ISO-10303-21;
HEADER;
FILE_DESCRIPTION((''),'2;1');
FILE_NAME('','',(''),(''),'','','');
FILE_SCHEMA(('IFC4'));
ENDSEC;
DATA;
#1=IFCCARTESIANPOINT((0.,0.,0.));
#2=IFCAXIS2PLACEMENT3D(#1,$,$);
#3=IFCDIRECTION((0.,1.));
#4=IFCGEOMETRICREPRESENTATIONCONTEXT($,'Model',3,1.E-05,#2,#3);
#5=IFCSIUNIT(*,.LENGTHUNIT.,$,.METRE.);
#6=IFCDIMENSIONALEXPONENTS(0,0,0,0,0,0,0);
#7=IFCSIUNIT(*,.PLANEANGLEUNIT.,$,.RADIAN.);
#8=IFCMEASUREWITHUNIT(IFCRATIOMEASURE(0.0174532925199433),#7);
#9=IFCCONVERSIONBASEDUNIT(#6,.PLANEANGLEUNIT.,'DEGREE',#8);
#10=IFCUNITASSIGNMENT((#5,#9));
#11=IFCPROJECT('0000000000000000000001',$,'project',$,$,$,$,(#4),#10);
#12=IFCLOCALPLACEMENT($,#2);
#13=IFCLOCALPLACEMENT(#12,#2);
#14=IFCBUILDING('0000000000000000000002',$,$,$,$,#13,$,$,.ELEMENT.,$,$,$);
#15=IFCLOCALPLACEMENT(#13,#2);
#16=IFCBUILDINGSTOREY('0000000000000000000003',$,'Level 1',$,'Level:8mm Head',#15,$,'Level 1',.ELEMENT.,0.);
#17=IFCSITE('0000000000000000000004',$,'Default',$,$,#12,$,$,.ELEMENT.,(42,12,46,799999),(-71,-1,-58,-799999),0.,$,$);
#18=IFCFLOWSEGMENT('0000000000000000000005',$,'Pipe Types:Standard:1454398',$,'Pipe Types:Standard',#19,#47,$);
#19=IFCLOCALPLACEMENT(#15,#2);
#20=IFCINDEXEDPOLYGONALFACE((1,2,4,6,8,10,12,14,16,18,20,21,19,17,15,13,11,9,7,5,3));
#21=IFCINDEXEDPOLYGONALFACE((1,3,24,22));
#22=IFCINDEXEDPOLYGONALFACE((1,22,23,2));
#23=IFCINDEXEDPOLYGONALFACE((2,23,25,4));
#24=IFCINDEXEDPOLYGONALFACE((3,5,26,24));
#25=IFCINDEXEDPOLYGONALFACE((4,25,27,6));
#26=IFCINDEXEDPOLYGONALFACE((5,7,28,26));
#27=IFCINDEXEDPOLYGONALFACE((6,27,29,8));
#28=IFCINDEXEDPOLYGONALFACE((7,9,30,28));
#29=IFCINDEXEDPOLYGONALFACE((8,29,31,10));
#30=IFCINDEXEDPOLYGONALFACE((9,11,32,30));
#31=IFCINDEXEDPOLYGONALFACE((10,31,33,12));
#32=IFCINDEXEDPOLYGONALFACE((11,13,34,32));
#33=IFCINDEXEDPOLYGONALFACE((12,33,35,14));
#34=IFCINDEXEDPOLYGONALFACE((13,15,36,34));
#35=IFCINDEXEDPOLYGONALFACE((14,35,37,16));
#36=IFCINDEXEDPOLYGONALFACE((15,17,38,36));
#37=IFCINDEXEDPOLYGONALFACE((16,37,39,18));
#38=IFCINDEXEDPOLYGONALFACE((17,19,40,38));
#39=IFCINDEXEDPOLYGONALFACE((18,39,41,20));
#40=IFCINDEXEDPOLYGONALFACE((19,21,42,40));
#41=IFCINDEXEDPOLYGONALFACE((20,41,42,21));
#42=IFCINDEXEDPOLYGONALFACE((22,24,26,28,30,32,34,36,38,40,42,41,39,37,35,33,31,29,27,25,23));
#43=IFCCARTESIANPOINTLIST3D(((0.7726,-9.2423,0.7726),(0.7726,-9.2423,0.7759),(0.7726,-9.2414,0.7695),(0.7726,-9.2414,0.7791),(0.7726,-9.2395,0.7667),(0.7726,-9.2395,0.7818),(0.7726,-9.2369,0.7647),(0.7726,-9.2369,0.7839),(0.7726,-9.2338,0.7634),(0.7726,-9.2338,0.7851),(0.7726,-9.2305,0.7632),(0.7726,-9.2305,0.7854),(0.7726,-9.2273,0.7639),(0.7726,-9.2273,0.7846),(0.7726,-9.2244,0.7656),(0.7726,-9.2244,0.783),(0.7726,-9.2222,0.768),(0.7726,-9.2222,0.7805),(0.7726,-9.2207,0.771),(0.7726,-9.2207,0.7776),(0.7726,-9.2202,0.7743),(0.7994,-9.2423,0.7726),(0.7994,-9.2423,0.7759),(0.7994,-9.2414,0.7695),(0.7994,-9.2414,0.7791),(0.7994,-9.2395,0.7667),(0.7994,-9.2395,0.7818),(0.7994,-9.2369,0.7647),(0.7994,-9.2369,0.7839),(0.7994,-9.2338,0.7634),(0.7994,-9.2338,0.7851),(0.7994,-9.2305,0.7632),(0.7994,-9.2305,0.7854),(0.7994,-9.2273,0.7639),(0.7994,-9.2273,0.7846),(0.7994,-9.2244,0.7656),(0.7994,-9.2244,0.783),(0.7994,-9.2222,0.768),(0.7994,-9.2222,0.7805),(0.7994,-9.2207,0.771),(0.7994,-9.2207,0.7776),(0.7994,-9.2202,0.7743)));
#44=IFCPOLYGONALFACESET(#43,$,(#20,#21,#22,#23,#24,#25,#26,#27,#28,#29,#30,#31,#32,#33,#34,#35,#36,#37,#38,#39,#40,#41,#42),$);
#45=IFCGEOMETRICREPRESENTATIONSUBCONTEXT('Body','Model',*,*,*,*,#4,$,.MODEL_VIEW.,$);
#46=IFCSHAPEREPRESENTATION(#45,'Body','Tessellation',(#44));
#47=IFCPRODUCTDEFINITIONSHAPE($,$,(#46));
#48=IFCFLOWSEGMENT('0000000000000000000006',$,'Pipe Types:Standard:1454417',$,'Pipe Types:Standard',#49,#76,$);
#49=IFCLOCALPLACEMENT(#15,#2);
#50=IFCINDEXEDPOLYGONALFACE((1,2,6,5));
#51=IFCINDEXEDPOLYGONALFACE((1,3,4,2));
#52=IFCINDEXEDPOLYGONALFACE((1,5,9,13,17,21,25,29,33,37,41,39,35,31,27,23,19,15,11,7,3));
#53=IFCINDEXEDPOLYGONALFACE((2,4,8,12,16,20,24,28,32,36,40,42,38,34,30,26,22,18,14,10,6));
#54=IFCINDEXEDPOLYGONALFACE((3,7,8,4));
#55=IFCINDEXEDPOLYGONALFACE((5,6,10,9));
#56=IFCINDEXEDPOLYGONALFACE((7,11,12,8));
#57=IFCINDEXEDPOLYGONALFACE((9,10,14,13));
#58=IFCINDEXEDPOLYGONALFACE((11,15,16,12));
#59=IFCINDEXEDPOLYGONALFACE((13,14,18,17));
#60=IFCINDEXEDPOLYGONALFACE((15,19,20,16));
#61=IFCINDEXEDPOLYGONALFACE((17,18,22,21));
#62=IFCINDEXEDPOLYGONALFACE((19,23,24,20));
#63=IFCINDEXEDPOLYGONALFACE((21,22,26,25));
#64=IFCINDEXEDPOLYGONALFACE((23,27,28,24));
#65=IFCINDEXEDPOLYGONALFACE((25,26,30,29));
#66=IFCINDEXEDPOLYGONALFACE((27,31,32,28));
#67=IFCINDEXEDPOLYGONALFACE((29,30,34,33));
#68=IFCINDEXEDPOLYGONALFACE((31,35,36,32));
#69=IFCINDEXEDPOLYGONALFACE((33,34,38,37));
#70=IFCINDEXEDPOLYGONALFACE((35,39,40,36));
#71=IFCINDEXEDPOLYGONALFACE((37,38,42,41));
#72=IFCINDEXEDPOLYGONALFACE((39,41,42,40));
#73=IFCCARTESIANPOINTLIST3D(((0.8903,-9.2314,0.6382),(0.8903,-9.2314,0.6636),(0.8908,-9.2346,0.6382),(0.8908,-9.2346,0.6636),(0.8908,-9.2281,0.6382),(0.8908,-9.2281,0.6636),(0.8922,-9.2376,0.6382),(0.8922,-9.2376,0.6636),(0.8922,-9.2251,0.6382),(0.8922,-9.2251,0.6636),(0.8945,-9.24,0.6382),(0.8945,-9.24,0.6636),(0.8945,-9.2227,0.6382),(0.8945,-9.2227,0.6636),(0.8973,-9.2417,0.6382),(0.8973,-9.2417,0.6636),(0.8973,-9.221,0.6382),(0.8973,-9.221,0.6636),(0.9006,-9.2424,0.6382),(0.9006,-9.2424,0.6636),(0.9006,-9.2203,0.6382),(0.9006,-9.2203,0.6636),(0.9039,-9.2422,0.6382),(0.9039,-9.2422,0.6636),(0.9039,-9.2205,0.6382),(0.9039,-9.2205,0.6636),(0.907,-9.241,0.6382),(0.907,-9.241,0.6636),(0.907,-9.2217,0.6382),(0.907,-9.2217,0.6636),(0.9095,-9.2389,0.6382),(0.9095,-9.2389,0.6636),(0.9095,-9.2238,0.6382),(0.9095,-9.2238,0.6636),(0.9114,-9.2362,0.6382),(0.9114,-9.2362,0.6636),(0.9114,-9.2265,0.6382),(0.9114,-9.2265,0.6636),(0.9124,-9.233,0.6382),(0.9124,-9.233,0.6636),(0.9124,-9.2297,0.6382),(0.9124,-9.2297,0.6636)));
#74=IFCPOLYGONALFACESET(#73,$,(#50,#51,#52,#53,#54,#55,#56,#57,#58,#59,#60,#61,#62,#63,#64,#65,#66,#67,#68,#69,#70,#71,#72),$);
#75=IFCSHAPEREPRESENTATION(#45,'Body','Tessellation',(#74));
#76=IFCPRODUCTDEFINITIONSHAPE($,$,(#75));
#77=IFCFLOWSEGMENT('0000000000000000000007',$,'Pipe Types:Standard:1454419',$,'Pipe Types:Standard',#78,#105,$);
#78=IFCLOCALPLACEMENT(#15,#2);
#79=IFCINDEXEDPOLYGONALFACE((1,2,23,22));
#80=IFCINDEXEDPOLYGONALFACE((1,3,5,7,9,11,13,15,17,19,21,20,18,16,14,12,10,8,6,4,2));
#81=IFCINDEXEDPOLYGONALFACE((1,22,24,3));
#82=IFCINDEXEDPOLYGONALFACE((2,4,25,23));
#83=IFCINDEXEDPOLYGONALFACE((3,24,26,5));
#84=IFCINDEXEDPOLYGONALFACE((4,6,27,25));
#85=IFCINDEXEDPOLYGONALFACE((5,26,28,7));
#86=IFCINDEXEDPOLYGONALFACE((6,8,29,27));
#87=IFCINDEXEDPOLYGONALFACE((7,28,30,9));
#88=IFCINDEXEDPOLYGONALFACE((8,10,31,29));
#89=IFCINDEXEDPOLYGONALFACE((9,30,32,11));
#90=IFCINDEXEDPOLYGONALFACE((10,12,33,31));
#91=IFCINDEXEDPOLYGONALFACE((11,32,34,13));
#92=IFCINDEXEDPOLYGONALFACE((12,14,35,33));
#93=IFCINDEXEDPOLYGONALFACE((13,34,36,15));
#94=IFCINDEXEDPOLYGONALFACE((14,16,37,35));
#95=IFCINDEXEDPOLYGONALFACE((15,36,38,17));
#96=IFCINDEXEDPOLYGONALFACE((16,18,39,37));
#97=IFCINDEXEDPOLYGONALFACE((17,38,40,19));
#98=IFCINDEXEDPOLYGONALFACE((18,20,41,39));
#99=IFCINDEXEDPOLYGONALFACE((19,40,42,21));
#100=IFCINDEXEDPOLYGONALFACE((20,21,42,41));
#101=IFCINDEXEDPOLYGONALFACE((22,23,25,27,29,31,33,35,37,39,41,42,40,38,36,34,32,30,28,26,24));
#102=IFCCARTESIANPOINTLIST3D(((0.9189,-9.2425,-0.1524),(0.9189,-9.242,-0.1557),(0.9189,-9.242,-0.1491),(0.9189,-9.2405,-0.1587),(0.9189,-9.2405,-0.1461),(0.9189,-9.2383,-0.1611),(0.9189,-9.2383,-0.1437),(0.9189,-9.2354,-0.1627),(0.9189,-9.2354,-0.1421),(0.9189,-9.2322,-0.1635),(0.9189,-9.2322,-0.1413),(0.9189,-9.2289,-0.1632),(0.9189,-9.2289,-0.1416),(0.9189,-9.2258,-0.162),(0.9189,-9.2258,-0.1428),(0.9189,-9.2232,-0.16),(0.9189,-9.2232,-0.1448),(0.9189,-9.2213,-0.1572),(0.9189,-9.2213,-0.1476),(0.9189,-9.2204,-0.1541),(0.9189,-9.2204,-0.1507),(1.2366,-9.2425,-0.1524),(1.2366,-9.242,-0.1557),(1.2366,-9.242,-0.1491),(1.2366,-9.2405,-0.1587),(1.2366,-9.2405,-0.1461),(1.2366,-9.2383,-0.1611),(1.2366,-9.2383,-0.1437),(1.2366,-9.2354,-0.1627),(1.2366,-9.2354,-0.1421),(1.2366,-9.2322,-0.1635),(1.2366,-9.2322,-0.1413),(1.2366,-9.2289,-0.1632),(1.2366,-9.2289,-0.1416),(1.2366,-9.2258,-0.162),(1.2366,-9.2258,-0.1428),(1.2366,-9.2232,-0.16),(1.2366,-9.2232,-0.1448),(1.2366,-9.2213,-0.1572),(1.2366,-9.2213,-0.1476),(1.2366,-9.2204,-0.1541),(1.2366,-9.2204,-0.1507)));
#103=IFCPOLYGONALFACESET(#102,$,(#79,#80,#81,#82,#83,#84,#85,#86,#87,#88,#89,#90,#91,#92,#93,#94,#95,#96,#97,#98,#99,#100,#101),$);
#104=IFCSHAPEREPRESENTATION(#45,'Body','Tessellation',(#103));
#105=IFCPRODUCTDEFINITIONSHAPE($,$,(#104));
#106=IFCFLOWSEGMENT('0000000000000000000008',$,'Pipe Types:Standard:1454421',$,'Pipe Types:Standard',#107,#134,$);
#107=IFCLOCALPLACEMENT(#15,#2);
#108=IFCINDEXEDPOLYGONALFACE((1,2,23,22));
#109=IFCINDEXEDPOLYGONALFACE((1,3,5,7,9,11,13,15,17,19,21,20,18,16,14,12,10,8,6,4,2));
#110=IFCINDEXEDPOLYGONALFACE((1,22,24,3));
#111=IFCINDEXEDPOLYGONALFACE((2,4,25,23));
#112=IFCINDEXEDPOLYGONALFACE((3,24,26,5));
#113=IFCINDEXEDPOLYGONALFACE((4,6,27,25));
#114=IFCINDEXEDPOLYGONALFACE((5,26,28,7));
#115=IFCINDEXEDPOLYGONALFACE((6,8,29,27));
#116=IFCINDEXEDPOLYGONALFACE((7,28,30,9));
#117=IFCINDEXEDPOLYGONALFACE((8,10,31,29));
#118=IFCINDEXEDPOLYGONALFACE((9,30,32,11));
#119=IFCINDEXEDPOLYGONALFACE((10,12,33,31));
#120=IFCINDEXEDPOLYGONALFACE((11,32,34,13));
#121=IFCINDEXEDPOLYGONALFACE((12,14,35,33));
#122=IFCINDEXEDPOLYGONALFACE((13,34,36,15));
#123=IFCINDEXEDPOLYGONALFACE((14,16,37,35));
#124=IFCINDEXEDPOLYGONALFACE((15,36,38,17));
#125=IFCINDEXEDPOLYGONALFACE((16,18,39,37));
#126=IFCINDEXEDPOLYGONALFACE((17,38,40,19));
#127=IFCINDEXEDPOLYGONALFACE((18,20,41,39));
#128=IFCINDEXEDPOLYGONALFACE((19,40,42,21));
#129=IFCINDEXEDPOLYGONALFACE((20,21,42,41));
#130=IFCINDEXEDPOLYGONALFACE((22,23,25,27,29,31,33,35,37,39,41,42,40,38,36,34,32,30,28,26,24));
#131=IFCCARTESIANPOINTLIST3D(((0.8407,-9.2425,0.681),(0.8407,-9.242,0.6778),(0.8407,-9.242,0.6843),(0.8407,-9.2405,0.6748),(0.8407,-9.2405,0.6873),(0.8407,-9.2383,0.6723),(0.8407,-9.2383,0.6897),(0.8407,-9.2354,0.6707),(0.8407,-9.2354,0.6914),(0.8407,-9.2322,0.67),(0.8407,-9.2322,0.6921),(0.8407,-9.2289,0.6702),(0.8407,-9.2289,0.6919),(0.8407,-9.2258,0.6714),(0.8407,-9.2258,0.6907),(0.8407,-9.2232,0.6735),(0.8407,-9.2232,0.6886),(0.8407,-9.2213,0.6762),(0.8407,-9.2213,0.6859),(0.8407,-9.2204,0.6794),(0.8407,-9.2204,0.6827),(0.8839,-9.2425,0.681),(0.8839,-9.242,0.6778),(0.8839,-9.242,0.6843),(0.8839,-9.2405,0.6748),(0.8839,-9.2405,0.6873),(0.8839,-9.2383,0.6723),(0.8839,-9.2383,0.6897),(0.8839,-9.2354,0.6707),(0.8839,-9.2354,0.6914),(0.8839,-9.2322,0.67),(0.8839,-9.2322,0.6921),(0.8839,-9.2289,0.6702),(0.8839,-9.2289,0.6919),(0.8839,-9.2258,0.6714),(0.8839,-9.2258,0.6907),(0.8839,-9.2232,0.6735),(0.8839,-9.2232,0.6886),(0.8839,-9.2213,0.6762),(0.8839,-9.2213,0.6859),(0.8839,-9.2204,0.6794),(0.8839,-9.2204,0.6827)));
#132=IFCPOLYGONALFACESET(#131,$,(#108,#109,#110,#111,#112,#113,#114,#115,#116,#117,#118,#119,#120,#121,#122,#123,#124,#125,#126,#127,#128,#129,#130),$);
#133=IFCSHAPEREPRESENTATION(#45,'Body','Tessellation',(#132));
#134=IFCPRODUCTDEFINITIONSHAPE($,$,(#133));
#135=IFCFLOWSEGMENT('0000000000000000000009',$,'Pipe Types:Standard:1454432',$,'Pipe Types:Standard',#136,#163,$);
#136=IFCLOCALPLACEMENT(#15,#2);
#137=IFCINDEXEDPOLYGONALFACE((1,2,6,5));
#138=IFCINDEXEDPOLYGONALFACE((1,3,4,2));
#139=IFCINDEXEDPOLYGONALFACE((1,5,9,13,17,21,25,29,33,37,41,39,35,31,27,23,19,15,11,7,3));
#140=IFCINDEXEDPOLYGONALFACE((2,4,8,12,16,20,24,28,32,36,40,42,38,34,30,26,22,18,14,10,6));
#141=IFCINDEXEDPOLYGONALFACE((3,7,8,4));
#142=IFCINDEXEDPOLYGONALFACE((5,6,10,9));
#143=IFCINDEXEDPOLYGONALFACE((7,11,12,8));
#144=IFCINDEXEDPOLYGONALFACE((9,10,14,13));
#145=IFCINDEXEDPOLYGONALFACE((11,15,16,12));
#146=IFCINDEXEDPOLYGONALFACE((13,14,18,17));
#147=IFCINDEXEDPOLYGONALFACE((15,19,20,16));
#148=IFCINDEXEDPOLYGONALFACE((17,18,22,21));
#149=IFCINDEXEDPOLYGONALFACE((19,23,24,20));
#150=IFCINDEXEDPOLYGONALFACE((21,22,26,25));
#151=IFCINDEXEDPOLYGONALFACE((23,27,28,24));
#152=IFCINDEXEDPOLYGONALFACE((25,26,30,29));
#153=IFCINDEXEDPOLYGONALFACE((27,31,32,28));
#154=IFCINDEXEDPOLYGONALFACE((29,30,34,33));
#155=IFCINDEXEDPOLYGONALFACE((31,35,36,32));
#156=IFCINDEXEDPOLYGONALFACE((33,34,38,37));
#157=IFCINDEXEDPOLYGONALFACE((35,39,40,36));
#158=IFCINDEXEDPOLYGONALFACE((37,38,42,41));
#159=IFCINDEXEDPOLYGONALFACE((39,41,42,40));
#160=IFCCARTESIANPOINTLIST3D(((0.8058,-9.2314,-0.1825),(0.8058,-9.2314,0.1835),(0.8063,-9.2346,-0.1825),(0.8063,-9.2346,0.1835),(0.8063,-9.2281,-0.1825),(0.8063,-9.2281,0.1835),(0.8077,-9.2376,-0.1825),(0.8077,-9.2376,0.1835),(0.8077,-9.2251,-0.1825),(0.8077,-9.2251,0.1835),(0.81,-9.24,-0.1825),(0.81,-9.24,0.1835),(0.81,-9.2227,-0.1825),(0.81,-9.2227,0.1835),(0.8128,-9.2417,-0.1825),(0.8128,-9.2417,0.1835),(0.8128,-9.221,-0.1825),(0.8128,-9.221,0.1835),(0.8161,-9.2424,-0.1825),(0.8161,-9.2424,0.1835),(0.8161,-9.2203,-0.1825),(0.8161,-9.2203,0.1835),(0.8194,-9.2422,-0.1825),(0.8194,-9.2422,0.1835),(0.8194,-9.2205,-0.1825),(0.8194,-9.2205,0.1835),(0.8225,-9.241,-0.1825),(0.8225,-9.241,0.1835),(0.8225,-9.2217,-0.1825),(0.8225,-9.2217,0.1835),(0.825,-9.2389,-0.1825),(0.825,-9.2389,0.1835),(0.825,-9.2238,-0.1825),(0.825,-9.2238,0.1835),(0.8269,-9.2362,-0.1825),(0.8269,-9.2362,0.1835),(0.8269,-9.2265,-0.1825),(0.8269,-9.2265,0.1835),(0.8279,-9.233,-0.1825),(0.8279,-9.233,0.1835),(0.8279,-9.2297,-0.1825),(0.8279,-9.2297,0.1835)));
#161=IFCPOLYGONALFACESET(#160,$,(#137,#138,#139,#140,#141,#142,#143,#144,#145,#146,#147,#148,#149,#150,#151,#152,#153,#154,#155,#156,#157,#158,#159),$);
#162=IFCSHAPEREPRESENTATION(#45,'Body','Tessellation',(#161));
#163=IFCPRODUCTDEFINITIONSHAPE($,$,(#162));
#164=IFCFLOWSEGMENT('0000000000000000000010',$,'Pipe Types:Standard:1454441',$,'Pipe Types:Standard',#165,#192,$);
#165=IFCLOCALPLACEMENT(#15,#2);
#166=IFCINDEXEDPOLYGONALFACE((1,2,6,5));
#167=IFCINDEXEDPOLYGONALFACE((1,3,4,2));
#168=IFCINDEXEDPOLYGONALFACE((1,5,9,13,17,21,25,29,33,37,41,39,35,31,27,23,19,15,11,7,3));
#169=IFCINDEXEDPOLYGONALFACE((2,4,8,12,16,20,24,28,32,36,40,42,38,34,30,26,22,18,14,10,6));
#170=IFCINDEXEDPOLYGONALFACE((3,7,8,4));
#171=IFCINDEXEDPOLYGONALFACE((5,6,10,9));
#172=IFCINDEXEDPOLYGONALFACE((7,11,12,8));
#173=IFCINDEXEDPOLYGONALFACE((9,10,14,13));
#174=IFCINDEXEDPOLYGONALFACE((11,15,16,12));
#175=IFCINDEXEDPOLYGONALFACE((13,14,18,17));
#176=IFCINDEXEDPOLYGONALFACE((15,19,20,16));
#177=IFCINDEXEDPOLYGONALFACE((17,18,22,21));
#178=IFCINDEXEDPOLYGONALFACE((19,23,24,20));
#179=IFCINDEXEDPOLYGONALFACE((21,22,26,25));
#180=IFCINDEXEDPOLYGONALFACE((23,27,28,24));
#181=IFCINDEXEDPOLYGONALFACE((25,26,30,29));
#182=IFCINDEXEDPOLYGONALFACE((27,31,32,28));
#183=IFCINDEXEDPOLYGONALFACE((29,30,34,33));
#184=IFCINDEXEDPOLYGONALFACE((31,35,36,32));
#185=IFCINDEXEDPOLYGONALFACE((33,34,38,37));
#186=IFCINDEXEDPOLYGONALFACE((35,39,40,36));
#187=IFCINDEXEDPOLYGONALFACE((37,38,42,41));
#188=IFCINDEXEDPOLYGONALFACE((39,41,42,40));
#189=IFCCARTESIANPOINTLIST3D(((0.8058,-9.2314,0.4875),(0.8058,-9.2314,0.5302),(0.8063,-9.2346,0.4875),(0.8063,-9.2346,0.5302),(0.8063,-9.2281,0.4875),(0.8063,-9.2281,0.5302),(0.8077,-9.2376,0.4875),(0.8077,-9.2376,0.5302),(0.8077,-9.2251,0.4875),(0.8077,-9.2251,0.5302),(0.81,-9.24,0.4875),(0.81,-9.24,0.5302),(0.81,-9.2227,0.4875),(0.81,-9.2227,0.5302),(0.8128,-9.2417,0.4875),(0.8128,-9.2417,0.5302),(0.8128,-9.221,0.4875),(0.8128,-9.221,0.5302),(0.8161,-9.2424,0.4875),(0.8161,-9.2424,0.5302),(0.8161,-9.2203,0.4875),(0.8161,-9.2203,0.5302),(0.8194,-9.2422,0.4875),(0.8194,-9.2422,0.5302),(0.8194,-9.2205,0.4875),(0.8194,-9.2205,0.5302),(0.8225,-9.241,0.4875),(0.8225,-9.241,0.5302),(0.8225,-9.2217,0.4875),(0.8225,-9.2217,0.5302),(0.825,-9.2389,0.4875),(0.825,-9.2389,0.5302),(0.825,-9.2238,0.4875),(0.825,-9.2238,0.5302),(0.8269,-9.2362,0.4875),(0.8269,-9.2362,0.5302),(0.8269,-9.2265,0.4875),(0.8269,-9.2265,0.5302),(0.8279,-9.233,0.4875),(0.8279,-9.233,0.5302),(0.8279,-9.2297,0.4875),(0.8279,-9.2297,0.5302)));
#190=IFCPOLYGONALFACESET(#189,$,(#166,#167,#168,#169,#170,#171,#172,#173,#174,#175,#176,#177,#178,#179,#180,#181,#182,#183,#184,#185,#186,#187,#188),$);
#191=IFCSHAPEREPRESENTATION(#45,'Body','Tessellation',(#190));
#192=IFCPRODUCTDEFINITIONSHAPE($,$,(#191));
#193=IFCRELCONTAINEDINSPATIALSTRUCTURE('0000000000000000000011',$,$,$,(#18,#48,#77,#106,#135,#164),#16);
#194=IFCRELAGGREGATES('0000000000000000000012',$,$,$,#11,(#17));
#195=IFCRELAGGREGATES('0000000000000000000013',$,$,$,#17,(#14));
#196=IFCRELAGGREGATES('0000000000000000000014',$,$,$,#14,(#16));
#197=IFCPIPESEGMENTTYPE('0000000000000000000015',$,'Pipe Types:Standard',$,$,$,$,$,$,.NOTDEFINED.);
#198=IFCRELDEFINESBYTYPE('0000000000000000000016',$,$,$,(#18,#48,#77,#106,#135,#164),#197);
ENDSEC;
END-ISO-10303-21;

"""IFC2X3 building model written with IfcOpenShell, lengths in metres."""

from ifc_helpers import new_model, entity, si_unit, converted_unit, direction, frame, frame_2d, origin, origin_2d_with_axis, place, context, subcontext, project, spatial, circle, extrude, type_object, element, save


model = new_model("IFC2X3")

# Units and contexts
model_context = context("Model", 3, precision=1e-05, world=origin(), true_north=direction((0.0, 1.0)))
body_context = subcontext(model_context, "Body", "Model", "MODEL_VIEW")
ifc_project = project(units=[si_unit("LENGTHUNIT", "METRE"), converted_unit("PLANEANGLEUNIT", "DEGREE", entity("IfcRatioMeasure", 0.0174532925199433), si_unit("PLANEANGLEUNIT", "RADIAN"), dimensions=[0, 0, 0, 0, 0, 0, 0])], contexts=[model_context])

# Site, building, storey
site_placement = place(None, origin())
site = spatial("IfcSite", under=ifc_project, at=site_placement, Name="Default", CompositionType="ELEMENT", RefLatitude=(42, 12, 46, 799999), RefLongitude=(-71, -1, -58, -799999), RefElevation=0.0)
building_placement = place(site_placement, origin())
building = spatial("IfcBuilding", under=site, at=building_placement, CompositionType="ELEMENT")
storey_placement = place(building_placement, origin())
storey = spatial("IfcBuildingStorey", under=building, at=storey_placement, Name="Level 1", ObjectType="Level:8mm Head", LongName="Level 1", CompositionType="ELEMENT", Elevation=0.0)

# Flow segments
pipe_segment_type = type_object("IfcPipeSegmentType", Name="Pipe Types:Standard", PredefinedType="NOTDEFINED")
flow_segment_1_placement = place(storey_placement, origin())
element("IfcFlowSegment", 1, at=flow_segment_1_placement, inside=storey, type_object=pipe_segment_type, Name="Pipe Types:Standard:1454398", ObjectType="Pipe Types:Standard", context=body_context, shape_type="SweptSolid", body=[
    extrude(circle(Radius=0.0111, at=frame_2d((0.0, 0.0), x_axis=(1.0, 0.0))), frame((0.7726, -9.2314, 0.7743), z_axis=(1.0, 0.0, 0.0), x_axis=(0.0, 1.0, 0.0)), (0.0, 0.0, 1.0), 0.0269),
])
flow_segment_2_placement = place(storey_placement, origin())
element("IfcFlowSegment", 2, at=flow_segment_2_placement, inside=storey, type_object=pipe_segment_type, Name="Pipe Types:Standard:1454417", ObjectType="Pipe Types:Standard", context=body_context, shape_type="SweptSolid", body=[
    extrude(circle(Radius=0.0111, at=origin_2d_with_axis()), frame((0.9014, -9.2314, 0.6382), z_axis=(0.0, 0.0, 1.0), x_axis=(-1.0, 0.0, 0.0)), (0.0, 0.0, 1.0), 0.0253),
])
flow_segment_3_placement = place(storey_placement, origin())
element("IfcFlowSegment", 3, at=flow_segment_3_placement, inside=storey, type_object=pipe_segment_type, Name="Pipe Types:Standard:1454419", ObjectType="Pipe Types:Standard", context=body_context, shape_type="SweptSolid", body=[
    extrude(circle(Radius=0.0111, at=frame_2d((0.0, 0.0), x_axis=(1.0, 0.0))), frame((0.9189, -9.2314, -0.1524), z_axis=(1.0, 0.0, 0.0), x_axis=(0.0, -1.0, 0.0)), (0.0, 0.0, 1.0), 0.3177),
])
flow_segment_4_placement = place(storey_placement, origin())
element("IfcFlowSegment", 4, at=flow_segment_4_placement, inside=storey, type_object=pipe_segment_type, Name="Pipe Types:Standard:1454421", ObjectType="Pipe Types:Standard", context=body_context, shape_type="SweptSolid", body=[
    extrude(circle(Radius=0.0111, at=frame_2d((0.0, 0.0), x_axis=(1.0, 0.0))), frame((0.8407, -9.2314, 0.681), z_axis=(1.0, 0.0, 0.0), x_axis=(0.0, -1.0, 0.0)), (0.0, 0.0, 1.0), 0.0432),
])
flow_segment_5_placement = place(storey_placement, origin())
element("IfcFlowSegment", 5, at=flow_segment_5_placement, inside=storey, type_object=pipe_segment_type, Name="Pipe Types:Standard:1454432", ObjectType="Pipe Types:Standard", context=body_context, shape_type="SweptSolid", body=[
    extrude(circle(Radius=0.0111, at=frame_2d((0.0, 0.0), x_axis=(1.0, 0.0))), frame((0.8169, -9.2314, -0.1825), z_axis=(0.0, 0.0, 1.0), x_axis=(-1.0, 0.0, 0.0)), (0.0, 0.0, 1.0), 0.366),
])
flow_segment_6_placement = place(storey_placement, origin())
element("IfcFlowSegment", 6, at=flow_segment_6_placement, inside=storey, type_object=pipe_segment_type, Name="Pipe Types:Standard:1454441", ObjectType="Pipe Types:Standard", context=body_context, shape_type="SweptSolid", body=[
    extrude(circle(Radius=0.0111, at=frame_2d((0.0, 0.0), x_axis=(1.0, 0.0))), frame((0.8169, -9.2314, 0.4875), z_axis=(0.0, 0.0, 1.0), x_axis=(-1.0, 0.0, 0.0)), (0.0, 0.0, 1.0), 0.0426),
])

save(model, "model.ifc")
